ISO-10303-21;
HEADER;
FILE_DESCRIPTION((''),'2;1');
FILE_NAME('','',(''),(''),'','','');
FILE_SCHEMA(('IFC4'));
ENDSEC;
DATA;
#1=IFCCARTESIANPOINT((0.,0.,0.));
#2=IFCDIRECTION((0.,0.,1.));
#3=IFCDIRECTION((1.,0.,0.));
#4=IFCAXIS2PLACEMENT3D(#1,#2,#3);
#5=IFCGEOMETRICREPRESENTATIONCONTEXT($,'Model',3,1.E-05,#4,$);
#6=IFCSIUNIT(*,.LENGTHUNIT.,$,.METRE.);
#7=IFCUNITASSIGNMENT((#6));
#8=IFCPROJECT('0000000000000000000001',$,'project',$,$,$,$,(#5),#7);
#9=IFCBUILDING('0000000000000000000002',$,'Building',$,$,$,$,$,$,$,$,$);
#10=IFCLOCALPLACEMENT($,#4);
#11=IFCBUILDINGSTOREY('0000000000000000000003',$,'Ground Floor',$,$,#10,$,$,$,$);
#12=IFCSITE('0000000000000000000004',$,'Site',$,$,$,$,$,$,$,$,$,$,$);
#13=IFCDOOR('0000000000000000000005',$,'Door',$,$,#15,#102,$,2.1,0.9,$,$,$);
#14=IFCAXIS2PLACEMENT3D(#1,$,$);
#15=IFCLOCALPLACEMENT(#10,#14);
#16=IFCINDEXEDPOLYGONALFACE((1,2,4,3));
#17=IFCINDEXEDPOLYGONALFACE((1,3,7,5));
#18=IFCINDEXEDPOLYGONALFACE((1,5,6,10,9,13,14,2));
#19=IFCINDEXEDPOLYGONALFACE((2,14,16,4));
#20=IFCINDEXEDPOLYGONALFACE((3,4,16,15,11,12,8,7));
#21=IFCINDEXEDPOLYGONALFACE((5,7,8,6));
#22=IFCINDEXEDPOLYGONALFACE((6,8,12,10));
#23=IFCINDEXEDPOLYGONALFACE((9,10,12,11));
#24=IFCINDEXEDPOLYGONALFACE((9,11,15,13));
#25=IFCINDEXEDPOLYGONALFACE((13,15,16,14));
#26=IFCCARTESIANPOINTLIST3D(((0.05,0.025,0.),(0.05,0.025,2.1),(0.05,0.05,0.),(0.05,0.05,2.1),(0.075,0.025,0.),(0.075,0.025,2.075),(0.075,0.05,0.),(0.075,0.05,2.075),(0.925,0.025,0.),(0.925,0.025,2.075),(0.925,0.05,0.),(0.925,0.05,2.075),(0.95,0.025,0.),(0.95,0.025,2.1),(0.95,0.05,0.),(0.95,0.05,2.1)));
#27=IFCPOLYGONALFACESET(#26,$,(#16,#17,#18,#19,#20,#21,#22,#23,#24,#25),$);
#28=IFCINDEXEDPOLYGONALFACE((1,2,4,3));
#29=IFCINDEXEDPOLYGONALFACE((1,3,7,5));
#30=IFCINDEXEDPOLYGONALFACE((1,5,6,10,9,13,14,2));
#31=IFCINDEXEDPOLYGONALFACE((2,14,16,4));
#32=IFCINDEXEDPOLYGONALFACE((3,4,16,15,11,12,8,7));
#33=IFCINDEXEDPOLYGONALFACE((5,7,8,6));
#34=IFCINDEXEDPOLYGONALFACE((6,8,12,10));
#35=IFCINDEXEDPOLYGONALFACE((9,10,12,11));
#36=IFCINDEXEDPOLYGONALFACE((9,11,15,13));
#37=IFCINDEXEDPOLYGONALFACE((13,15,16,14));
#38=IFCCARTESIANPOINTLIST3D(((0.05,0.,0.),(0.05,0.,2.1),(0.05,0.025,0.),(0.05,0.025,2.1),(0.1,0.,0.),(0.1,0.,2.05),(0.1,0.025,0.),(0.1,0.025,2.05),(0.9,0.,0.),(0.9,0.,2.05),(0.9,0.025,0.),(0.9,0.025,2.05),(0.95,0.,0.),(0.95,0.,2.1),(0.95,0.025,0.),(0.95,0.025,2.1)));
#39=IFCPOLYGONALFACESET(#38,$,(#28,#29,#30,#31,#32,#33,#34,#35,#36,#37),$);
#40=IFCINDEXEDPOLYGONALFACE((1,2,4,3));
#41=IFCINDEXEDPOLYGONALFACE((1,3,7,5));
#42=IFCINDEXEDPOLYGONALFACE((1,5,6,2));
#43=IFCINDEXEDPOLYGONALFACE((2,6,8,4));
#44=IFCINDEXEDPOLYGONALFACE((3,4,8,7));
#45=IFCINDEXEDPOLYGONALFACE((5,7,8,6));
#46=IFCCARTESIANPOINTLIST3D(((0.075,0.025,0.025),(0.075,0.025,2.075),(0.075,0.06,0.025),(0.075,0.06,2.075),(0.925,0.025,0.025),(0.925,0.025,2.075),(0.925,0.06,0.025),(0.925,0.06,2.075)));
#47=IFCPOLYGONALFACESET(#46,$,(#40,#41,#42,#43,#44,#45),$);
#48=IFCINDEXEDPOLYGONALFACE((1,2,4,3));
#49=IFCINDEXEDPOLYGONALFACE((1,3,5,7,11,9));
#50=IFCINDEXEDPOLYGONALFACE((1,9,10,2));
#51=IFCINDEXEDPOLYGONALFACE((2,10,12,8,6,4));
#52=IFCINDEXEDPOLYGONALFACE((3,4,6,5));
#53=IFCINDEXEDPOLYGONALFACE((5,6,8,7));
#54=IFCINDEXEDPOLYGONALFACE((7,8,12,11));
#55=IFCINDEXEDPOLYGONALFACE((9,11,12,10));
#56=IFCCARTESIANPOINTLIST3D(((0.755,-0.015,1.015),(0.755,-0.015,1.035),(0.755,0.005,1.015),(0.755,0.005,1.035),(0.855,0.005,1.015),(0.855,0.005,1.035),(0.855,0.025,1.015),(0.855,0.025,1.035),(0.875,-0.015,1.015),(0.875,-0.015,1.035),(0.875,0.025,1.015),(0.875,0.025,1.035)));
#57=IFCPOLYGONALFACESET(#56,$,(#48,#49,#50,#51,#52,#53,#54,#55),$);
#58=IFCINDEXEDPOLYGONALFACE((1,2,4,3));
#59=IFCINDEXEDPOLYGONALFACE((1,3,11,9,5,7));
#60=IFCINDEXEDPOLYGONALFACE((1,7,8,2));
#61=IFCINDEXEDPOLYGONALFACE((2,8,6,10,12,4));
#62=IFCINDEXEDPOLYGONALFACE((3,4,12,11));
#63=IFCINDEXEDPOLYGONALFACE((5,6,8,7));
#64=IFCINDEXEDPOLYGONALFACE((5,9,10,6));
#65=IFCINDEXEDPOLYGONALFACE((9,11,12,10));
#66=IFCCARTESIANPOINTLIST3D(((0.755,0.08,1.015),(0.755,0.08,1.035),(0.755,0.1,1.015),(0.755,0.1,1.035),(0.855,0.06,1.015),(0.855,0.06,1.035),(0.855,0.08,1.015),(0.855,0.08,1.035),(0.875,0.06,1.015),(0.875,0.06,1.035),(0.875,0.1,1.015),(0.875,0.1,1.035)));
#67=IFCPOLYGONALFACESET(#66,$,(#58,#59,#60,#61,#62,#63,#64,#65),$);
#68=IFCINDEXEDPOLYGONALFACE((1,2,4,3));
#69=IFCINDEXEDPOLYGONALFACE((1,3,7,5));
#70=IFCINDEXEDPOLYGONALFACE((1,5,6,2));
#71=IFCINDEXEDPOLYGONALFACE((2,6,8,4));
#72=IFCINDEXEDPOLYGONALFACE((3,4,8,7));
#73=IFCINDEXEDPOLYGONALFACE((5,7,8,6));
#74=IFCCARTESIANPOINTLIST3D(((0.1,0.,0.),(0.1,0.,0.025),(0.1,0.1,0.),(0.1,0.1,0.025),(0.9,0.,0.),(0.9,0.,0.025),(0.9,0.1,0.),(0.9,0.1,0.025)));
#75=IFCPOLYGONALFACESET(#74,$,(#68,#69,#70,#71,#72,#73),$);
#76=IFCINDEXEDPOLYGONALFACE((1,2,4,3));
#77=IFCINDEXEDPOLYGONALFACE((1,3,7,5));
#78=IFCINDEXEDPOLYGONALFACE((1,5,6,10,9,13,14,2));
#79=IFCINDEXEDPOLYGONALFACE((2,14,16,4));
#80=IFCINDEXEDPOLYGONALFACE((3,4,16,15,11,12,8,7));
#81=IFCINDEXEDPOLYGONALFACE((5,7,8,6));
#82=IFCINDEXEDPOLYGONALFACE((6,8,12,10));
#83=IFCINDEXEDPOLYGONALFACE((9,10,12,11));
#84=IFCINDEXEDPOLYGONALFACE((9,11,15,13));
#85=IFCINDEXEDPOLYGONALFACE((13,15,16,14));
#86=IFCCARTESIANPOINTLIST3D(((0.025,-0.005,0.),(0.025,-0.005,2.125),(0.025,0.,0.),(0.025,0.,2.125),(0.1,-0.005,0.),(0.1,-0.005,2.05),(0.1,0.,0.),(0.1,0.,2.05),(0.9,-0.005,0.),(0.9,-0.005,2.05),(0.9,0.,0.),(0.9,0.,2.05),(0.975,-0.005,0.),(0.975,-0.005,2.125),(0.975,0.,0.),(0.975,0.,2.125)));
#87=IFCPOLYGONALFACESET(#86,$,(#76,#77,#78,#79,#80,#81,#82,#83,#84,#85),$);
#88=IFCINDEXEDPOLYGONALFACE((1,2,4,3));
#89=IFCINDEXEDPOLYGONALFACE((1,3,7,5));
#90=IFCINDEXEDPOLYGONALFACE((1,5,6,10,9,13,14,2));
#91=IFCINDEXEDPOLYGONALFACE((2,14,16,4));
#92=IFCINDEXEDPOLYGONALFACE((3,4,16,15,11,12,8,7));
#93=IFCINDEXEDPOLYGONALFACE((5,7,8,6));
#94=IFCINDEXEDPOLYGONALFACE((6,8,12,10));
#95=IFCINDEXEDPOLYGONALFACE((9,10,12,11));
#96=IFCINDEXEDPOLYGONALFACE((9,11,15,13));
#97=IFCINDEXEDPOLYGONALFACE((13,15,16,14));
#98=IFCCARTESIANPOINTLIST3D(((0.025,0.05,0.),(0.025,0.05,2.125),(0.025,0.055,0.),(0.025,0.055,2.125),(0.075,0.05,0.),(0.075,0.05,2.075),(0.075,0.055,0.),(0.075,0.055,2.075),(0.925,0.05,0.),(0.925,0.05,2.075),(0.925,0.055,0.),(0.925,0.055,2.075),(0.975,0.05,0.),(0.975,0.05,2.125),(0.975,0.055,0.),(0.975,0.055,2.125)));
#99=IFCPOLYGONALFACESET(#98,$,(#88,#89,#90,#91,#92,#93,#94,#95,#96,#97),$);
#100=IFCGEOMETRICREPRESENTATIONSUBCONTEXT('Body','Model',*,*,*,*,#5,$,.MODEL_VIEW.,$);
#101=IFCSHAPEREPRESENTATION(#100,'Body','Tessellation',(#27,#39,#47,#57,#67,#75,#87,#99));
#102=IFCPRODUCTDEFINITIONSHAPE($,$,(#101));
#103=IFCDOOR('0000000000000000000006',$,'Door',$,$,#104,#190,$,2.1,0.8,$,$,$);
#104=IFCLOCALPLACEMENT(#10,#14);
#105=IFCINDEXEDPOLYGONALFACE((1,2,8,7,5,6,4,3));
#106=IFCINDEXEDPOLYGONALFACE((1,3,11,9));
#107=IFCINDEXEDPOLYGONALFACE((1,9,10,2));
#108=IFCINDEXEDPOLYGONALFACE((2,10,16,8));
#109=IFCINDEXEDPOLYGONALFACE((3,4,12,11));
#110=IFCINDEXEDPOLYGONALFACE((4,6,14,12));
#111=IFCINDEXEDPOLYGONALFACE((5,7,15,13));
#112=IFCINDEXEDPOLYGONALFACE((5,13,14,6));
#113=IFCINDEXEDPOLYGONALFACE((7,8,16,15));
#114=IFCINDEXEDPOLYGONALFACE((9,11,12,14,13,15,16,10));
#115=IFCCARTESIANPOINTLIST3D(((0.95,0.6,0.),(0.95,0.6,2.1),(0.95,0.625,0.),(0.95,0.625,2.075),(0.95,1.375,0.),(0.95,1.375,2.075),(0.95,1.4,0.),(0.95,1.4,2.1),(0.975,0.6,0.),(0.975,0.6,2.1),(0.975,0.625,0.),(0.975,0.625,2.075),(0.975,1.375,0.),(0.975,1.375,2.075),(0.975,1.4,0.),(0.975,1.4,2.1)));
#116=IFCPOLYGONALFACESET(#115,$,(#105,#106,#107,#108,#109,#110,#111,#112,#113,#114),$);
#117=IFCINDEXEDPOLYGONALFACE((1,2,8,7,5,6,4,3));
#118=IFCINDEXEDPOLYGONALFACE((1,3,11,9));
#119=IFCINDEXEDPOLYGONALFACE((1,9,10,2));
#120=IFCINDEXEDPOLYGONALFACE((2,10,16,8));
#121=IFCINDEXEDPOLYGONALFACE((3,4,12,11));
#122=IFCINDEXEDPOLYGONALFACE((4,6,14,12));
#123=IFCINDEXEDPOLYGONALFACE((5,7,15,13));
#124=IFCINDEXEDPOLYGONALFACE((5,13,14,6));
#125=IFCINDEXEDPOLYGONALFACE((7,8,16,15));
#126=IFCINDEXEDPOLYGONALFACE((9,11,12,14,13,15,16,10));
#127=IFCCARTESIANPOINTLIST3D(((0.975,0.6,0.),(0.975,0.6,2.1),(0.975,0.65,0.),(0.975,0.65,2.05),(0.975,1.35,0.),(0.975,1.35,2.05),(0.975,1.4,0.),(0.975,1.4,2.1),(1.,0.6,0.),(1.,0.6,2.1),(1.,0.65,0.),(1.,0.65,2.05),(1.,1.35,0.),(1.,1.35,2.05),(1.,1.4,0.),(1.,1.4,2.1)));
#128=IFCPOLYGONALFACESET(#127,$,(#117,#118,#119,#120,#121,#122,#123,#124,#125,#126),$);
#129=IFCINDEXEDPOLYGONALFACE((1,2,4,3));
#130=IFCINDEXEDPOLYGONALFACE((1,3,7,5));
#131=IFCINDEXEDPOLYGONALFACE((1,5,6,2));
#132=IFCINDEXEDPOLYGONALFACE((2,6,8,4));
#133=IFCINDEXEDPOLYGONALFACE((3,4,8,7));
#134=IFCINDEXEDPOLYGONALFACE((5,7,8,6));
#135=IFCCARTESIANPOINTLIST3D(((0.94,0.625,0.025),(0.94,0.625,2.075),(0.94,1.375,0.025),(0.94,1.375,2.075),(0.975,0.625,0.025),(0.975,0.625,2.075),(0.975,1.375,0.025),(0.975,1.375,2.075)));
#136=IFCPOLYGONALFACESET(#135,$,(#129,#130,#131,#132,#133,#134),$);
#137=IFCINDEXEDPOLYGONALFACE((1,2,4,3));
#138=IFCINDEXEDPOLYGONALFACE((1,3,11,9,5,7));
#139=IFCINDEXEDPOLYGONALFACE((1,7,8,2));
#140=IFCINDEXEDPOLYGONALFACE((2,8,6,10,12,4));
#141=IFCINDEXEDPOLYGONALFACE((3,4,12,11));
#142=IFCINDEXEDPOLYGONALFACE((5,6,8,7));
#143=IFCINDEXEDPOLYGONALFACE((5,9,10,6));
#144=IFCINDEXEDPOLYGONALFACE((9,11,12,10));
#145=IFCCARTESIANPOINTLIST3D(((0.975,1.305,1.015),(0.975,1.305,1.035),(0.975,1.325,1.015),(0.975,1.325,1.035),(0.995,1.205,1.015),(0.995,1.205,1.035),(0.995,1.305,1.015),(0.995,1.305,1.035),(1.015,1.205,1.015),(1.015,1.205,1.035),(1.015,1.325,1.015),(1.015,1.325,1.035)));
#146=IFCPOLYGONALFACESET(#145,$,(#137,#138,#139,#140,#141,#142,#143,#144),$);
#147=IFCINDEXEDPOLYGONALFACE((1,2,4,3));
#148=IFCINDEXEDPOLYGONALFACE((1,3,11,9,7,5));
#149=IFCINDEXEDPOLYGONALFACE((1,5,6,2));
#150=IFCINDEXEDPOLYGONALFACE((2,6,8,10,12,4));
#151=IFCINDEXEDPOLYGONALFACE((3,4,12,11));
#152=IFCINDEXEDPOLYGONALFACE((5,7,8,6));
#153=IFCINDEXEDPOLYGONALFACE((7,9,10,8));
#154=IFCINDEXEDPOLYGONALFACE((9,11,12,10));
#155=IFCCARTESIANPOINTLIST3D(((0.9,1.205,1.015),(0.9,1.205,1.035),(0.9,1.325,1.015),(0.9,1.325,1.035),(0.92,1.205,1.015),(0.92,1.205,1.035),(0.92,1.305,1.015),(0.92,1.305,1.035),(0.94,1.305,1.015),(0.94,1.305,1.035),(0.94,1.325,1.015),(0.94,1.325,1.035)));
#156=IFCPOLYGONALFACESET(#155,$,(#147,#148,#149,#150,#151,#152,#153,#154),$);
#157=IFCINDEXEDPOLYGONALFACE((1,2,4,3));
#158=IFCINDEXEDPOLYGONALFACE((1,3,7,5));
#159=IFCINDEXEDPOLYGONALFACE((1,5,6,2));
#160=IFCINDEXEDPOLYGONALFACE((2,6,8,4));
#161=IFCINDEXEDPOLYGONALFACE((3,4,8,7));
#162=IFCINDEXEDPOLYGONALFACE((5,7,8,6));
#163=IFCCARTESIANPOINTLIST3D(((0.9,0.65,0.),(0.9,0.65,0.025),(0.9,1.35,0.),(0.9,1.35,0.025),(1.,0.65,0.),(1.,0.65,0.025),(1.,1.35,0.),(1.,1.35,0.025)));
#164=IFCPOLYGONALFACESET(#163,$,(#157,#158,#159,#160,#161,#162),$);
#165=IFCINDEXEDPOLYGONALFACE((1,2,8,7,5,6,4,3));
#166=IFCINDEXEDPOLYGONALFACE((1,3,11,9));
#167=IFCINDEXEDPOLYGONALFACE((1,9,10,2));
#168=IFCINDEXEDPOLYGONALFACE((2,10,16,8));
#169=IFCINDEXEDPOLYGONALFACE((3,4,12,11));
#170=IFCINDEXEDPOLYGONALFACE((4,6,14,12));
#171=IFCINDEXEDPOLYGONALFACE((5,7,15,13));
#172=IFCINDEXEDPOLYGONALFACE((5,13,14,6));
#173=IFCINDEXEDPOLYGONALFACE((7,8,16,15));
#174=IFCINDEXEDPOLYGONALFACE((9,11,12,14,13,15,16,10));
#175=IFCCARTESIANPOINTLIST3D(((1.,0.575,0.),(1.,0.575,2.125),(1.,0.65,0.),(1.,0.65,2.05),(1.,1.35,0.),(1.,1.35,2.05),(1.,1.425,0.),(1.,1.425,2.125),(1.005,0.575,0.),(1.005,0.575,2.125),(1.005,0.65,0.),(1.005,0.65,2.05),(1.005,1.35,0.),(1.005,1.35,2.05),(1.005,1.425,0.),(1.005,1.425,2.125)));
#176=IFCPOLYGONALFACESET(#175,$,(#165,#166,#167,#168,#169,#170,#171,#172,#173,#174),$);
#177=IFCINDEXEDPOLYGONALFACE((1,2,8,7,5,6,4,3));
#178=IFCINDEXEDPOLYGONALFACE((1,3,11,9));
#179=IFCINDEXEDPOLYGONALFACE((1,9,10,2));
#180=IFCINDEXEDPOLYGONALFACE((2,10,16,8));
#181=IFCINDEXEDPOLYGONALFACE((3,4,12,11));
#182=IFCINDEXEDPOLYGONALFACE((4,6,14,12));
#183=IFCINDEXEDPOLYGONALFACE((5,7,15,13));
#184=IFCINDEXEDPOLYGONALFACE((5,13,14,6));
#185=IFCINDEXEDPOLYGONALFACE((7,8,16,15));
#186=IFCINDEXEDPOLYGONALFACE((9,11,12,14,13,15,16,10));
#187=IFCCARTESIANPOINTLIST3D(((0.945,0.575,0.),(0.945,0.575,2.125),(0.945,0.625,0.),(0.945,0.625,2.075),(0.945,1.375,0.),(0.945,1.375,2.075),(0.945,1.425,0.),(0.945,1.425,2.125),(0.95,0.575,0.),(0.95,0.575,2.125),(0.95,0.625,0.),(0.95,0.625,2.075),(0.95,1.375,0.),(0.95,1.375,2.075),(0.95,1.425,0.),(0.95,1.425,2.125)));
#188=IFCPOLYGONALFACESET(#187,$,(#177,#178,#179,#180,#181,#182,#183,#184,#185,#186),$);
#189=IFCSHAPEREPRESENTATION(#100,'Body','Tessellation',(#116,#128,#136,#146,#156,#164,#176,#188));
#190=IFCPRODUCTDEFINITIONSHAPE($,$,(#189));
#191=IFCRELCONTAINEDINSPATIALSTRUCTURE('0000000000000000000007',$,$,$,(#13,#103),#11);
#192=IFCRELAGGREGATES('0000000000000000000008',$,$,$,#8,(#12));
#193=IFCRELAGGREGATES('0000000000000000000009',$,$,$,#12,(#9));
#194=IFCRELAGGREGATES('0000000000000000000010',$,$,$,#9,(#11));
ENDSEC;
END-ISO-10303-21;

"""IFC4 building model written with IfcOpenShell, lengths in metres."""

from ifc_helpers import new_model, si_unit, frame, origin_with_axes, place, context, subcontext, project, spatial, line, indexed_curve, outline, extrude, element, save


model = new_model("IFC4")

# Units and contexts
model_context = context("Model", 3, precision=1e-05, world=origin_with_axes())
body_context = subcontext(model_context, "Body", "Model", "MODEL_VIEW")
ifc_project = project(units=[si_unit("LENGTHUNIT", "METRE")], contexts=[model_context])

# Site, building, storey
site = spatial("IfcSite", under=ifc_project, Name="Site")
building = spatial("IfcBuilding", under=site, Name="Building")
storey_placement = place(None, origin_with_axes())
storey = spatial("IfcBuildingStorey", under=building, at=storey_placement, Name="Ground Floor")

# Doors
door_1_placement = place(storey_placement, frame((0.05, 0.0, 0.0), z_axis=(0.0, 0.0, 1.0), x_axis=(1.0, 0.0, 0.0)))
element("IfcDoor", 1, at=door_1_placement, inside=storey, Name="Door", OverallHeight=2.1, OverallWidth=0.9, context=body_context, shape_type="SweptSolid", body=[
    extrude(outline(indexed_curve([(0.0, 0.0), (0.0, 2.1), (0.9, 2.1), (0.9, 0.0), (0.875, 0.0), (0.875, 2.075), (0.025, 2.075), (0.025, 0.0)], segments=[line(1, 2, 3, 4, 5, 6, 7, 8, 1)])), frame((0.0, 0.025, 0.0), z_axis=(0.0, -1.0, 0.0), x_axis=(1.0, 0.0, 0.0)), (0.0, 0.0, -1.0), 0.025),
    extrude(outline(indexed_curve([(0.0, 0.0), (0.0, 2.1), (0.9, 2.1), (0.9, 0.0), (0.85, 0.0), (0.85, 2.05), (0.05, 2.05), (0.05, 0.0)], segments=[line(1, 2, 3, 4, 5, 6, 7, 8, 1)])), frame((0.0, 0.0, 0.0), z_axis=(0.0, -1.0, 0.0), x_axis=(1.0, 0.0, 0.0)), (0.0, 0.0, -1.0), 0.025),
    extrude(outline(indexed_curve([(0.0, 0.0), (0.85, 0.0), (0.85, 0.035), (0.0, 0.035)], segments=[line(1, 2, 3, 4, 1)])), frame((0.025, 0.025, 0.025), z_axis=(0.0, 0.0, 1.0), x_axis=(1.0, 0.0, 0.0)), (0.0, 0.0, 1.0), 2.05),
    extrude(outline(indexed_curve([(0.0, 0.0), (0.0, -0.04), (-0.12, -0.04), (-0.12, -0.02), (-0.02, -0.02), (-0.02, 0.0)], segments=[line(1, 2, 3, 4, 5, 6, 1)])), frame((0.825, 0.025, 1.015), z_axis=(0.0, 0.0, 1.0), x_axis=(1.0, 0.0, 0.0)), (0.0, 0.0, 1.0), 0.02),
    extrude(outline(indexed_curve([(0.0, 0.0), (0.0, 0.04), (-0.12, 0.04), (-0.12, 0.02), (-0.02, 0.02), (-0.02, 0.0)], segments=[line(1, 2, 3, 4, 5, 6, 1)])), frame((0.825, 0.06, 1.015), z_axis=(0.0, 0.0, 1.0), x_axis=(1.0, 0.0, 0.0)), (0.0, 0.0, 1.0), 0.02),
    extrude(outline(indexed_curve([(0.0, 0.0), (0.8, 0.0), (0.8, 0.1), (0.0, 0.1)], segments=[line(1, 2, 3, 4, 1)])), frame((0.05, 0.0, 0.0), z_axis=(0.0, 0.0, 1.0), x_axis=(1.0, 0.0, 0.0)), (0.0, 0.0, 1.0), 0.025),
    extrude(outline(indexed_curve([(0.0, 0.0), (0.0, 2.125), (0.95, 2.125), (0.95, 0.0), (0.875, 0.0), (0.875, 2.05), (0.075, 2.05), (0.075, 0.0)], segments=[line(1, 2, 3, 4, 5, 6, 7, 8, 1)])), frame((-0.025, -0.005, 0.0), z_axis=(0.0, -1.0, 0.0), x_axis=(1.0, 0.0, 0.0)), (0.0, 0.0, -1.0), 0.005),
    extrude(outline(indexed_curve([(0.0, 0.0), (0.0, 2.125), (0.95, 2.125), (0.95, 0.0), (0.9, 0.0), (0.9, 2.075), (0.05, 2.075), (0.05, 0.0)], segments=[line(1, 2, 3, 4, 5, 6, 7, 8, 1)])), frame((-0.025, 0.05, 0.0), z_axis=(0.0, -1.0, 0.0), x_axis=(1.0, 0.0, 0.0)), (0.0, 0.0, -1.0), 0.005),
])
door_2_placement = place(storey_placement, frame((1.0, 0.6, 0.0), z_axis=(0.0, 0.0, 1.0), x_axis=(0.0, 1.0, 0.0)))
element("IfcDoor", 2, at=door_2_placement, inside=storey, Name="Door", OverallHeight=2.1, OverallWidth=0.8, context=body_context, shape_type="SweptSolid", body=[
    extrude(outline(indexed_curve([(0.0, 0.0), (0.0, 2.1), (0.8, 2.1), (0.8, 0.0), (0.775, 0.0), (0.775, 2.075), (0.025, 2.075), (0.025, 0.0)], segments=[line(1, 2, 3, 4, 5, 6, 7, 8, 1)])), frame((0.0, 0.025, 0.0), z_axis=(0.0, -1.0, 0.0), x_axis=(1.0, 0.0, 0.0)), (0.0, 0.0, -1.0), 0.025),
    extrude(outline(indexed_curve([(0.0, 0.0), (0.0, 2.1), (0.8, 2.1), (0.8, 0.0), (0.75, 0.0), (0.75, 2.05), (0.05, 2.05), (0.05, 0.0)], segments=[line(1, 2, 3, 4, 5, 6, 7, 8, 1)])), frame((0.0, 0.0, 0.0), z_axis=(0.0, -1.0, 0.0), x_axis=(1.0, 0.0, 0.0)), (0.0, 0.0, -1.0), 0.025),
    extrude(outline(indexed_curve([(0.0, 0.0), (0.75, 0.0), (0.75, 0.035), (0.0, 0.035)], segments=[line(1, 2, 3, 4, 1)])), frame((0.025, 0.025, 0.025), z_axis=(0.0, 0.0, 1.0), x_axis=(1.0, 0.0, 0.0)), (0.0, 0.0, 1.0), 2.05),
    extrude(outline(indexed_curve([(0.0, 0.0), (0.0, -0.04), (-0.12, -0.04), (-0.12, -0.02), (-0.02, -0.02), (-0.02, 0.0)], segments=[line(1, 2, 3, 4, 5, 6, 1)])), frame((0.725, 0.025, 1.015), z_axis=(0.0, 0.0, 1.0), x_axis=(1.0, 0.0, 0.0)), (0.0, 0.0, 1.0), 0.02),
    extrude(outline(indexed_curve([(0.0, 0.0), (0.0, 0.04), (-0.12, 0.04), (-0.12, 0.02), (-0.02, 0.02), (-0.02, 0.0)], segments=[line(1, 2, 3, 4, 5, 6, 1)])), frame((0.725, 0.06, 1.015), z_axis=(0.0, 0.0, 1.0), x_axis=(1.0, 0.0, 0.0)), (0.0, 0.0, 1.0), 0.02),
    extrude(outline(indexed_curve([(0.0, 0.0), (0.7, 0.0), (0.7, 0.1), (0.0, 0.1)], segments=[line(1, 2, 3, 4, 1)])), frame((0.05, 0.0, 0.0), z_axis=(0.0, 0.0, 1.0), x_axis=(1.0, 0.0, 0.0)), (0.0, 0.0, 1.0), 0.025),
    extrude(outline(indexed_curve([(0.0, 0.0), (0.0, 2.125), (0.85, 2.125), (0.85, 0.0), (0.775, 0.0), (0.775, 2.05), (0.075, 2.05), (0.075, 0.0)], segments=[line(1, 2, 3, 4, 5, 6, 7, 8, 1)])), frame((-0.025, -0.005, 0.0), z_axis=(0.0, -1.0, 0.0), x_axis=(1.0, 0.0, 0.0)), (0.0, 0.0, -1.0), 0.005),
    extrude(outline(indexed_curve([(0.0, 0.0), (0.0, 2.125), (0.85, 2.125), (0.85, 0.0), (0.8, 0.0), (0.8, 2.075), (0.05, 2.075), (0.05, 0.0)], segments=[line(1, 2, 3, 4, 5, 6, 7, 8, 1)])), frame((-0.025, 0.05, 0.0), z_axis=(0.0, -1.0, 0.0), x_axis=(1.0, 0.0, 0.0)), (0.0, 0.0, -1.0), 0.005),
])

save(model, "model.ifc")
